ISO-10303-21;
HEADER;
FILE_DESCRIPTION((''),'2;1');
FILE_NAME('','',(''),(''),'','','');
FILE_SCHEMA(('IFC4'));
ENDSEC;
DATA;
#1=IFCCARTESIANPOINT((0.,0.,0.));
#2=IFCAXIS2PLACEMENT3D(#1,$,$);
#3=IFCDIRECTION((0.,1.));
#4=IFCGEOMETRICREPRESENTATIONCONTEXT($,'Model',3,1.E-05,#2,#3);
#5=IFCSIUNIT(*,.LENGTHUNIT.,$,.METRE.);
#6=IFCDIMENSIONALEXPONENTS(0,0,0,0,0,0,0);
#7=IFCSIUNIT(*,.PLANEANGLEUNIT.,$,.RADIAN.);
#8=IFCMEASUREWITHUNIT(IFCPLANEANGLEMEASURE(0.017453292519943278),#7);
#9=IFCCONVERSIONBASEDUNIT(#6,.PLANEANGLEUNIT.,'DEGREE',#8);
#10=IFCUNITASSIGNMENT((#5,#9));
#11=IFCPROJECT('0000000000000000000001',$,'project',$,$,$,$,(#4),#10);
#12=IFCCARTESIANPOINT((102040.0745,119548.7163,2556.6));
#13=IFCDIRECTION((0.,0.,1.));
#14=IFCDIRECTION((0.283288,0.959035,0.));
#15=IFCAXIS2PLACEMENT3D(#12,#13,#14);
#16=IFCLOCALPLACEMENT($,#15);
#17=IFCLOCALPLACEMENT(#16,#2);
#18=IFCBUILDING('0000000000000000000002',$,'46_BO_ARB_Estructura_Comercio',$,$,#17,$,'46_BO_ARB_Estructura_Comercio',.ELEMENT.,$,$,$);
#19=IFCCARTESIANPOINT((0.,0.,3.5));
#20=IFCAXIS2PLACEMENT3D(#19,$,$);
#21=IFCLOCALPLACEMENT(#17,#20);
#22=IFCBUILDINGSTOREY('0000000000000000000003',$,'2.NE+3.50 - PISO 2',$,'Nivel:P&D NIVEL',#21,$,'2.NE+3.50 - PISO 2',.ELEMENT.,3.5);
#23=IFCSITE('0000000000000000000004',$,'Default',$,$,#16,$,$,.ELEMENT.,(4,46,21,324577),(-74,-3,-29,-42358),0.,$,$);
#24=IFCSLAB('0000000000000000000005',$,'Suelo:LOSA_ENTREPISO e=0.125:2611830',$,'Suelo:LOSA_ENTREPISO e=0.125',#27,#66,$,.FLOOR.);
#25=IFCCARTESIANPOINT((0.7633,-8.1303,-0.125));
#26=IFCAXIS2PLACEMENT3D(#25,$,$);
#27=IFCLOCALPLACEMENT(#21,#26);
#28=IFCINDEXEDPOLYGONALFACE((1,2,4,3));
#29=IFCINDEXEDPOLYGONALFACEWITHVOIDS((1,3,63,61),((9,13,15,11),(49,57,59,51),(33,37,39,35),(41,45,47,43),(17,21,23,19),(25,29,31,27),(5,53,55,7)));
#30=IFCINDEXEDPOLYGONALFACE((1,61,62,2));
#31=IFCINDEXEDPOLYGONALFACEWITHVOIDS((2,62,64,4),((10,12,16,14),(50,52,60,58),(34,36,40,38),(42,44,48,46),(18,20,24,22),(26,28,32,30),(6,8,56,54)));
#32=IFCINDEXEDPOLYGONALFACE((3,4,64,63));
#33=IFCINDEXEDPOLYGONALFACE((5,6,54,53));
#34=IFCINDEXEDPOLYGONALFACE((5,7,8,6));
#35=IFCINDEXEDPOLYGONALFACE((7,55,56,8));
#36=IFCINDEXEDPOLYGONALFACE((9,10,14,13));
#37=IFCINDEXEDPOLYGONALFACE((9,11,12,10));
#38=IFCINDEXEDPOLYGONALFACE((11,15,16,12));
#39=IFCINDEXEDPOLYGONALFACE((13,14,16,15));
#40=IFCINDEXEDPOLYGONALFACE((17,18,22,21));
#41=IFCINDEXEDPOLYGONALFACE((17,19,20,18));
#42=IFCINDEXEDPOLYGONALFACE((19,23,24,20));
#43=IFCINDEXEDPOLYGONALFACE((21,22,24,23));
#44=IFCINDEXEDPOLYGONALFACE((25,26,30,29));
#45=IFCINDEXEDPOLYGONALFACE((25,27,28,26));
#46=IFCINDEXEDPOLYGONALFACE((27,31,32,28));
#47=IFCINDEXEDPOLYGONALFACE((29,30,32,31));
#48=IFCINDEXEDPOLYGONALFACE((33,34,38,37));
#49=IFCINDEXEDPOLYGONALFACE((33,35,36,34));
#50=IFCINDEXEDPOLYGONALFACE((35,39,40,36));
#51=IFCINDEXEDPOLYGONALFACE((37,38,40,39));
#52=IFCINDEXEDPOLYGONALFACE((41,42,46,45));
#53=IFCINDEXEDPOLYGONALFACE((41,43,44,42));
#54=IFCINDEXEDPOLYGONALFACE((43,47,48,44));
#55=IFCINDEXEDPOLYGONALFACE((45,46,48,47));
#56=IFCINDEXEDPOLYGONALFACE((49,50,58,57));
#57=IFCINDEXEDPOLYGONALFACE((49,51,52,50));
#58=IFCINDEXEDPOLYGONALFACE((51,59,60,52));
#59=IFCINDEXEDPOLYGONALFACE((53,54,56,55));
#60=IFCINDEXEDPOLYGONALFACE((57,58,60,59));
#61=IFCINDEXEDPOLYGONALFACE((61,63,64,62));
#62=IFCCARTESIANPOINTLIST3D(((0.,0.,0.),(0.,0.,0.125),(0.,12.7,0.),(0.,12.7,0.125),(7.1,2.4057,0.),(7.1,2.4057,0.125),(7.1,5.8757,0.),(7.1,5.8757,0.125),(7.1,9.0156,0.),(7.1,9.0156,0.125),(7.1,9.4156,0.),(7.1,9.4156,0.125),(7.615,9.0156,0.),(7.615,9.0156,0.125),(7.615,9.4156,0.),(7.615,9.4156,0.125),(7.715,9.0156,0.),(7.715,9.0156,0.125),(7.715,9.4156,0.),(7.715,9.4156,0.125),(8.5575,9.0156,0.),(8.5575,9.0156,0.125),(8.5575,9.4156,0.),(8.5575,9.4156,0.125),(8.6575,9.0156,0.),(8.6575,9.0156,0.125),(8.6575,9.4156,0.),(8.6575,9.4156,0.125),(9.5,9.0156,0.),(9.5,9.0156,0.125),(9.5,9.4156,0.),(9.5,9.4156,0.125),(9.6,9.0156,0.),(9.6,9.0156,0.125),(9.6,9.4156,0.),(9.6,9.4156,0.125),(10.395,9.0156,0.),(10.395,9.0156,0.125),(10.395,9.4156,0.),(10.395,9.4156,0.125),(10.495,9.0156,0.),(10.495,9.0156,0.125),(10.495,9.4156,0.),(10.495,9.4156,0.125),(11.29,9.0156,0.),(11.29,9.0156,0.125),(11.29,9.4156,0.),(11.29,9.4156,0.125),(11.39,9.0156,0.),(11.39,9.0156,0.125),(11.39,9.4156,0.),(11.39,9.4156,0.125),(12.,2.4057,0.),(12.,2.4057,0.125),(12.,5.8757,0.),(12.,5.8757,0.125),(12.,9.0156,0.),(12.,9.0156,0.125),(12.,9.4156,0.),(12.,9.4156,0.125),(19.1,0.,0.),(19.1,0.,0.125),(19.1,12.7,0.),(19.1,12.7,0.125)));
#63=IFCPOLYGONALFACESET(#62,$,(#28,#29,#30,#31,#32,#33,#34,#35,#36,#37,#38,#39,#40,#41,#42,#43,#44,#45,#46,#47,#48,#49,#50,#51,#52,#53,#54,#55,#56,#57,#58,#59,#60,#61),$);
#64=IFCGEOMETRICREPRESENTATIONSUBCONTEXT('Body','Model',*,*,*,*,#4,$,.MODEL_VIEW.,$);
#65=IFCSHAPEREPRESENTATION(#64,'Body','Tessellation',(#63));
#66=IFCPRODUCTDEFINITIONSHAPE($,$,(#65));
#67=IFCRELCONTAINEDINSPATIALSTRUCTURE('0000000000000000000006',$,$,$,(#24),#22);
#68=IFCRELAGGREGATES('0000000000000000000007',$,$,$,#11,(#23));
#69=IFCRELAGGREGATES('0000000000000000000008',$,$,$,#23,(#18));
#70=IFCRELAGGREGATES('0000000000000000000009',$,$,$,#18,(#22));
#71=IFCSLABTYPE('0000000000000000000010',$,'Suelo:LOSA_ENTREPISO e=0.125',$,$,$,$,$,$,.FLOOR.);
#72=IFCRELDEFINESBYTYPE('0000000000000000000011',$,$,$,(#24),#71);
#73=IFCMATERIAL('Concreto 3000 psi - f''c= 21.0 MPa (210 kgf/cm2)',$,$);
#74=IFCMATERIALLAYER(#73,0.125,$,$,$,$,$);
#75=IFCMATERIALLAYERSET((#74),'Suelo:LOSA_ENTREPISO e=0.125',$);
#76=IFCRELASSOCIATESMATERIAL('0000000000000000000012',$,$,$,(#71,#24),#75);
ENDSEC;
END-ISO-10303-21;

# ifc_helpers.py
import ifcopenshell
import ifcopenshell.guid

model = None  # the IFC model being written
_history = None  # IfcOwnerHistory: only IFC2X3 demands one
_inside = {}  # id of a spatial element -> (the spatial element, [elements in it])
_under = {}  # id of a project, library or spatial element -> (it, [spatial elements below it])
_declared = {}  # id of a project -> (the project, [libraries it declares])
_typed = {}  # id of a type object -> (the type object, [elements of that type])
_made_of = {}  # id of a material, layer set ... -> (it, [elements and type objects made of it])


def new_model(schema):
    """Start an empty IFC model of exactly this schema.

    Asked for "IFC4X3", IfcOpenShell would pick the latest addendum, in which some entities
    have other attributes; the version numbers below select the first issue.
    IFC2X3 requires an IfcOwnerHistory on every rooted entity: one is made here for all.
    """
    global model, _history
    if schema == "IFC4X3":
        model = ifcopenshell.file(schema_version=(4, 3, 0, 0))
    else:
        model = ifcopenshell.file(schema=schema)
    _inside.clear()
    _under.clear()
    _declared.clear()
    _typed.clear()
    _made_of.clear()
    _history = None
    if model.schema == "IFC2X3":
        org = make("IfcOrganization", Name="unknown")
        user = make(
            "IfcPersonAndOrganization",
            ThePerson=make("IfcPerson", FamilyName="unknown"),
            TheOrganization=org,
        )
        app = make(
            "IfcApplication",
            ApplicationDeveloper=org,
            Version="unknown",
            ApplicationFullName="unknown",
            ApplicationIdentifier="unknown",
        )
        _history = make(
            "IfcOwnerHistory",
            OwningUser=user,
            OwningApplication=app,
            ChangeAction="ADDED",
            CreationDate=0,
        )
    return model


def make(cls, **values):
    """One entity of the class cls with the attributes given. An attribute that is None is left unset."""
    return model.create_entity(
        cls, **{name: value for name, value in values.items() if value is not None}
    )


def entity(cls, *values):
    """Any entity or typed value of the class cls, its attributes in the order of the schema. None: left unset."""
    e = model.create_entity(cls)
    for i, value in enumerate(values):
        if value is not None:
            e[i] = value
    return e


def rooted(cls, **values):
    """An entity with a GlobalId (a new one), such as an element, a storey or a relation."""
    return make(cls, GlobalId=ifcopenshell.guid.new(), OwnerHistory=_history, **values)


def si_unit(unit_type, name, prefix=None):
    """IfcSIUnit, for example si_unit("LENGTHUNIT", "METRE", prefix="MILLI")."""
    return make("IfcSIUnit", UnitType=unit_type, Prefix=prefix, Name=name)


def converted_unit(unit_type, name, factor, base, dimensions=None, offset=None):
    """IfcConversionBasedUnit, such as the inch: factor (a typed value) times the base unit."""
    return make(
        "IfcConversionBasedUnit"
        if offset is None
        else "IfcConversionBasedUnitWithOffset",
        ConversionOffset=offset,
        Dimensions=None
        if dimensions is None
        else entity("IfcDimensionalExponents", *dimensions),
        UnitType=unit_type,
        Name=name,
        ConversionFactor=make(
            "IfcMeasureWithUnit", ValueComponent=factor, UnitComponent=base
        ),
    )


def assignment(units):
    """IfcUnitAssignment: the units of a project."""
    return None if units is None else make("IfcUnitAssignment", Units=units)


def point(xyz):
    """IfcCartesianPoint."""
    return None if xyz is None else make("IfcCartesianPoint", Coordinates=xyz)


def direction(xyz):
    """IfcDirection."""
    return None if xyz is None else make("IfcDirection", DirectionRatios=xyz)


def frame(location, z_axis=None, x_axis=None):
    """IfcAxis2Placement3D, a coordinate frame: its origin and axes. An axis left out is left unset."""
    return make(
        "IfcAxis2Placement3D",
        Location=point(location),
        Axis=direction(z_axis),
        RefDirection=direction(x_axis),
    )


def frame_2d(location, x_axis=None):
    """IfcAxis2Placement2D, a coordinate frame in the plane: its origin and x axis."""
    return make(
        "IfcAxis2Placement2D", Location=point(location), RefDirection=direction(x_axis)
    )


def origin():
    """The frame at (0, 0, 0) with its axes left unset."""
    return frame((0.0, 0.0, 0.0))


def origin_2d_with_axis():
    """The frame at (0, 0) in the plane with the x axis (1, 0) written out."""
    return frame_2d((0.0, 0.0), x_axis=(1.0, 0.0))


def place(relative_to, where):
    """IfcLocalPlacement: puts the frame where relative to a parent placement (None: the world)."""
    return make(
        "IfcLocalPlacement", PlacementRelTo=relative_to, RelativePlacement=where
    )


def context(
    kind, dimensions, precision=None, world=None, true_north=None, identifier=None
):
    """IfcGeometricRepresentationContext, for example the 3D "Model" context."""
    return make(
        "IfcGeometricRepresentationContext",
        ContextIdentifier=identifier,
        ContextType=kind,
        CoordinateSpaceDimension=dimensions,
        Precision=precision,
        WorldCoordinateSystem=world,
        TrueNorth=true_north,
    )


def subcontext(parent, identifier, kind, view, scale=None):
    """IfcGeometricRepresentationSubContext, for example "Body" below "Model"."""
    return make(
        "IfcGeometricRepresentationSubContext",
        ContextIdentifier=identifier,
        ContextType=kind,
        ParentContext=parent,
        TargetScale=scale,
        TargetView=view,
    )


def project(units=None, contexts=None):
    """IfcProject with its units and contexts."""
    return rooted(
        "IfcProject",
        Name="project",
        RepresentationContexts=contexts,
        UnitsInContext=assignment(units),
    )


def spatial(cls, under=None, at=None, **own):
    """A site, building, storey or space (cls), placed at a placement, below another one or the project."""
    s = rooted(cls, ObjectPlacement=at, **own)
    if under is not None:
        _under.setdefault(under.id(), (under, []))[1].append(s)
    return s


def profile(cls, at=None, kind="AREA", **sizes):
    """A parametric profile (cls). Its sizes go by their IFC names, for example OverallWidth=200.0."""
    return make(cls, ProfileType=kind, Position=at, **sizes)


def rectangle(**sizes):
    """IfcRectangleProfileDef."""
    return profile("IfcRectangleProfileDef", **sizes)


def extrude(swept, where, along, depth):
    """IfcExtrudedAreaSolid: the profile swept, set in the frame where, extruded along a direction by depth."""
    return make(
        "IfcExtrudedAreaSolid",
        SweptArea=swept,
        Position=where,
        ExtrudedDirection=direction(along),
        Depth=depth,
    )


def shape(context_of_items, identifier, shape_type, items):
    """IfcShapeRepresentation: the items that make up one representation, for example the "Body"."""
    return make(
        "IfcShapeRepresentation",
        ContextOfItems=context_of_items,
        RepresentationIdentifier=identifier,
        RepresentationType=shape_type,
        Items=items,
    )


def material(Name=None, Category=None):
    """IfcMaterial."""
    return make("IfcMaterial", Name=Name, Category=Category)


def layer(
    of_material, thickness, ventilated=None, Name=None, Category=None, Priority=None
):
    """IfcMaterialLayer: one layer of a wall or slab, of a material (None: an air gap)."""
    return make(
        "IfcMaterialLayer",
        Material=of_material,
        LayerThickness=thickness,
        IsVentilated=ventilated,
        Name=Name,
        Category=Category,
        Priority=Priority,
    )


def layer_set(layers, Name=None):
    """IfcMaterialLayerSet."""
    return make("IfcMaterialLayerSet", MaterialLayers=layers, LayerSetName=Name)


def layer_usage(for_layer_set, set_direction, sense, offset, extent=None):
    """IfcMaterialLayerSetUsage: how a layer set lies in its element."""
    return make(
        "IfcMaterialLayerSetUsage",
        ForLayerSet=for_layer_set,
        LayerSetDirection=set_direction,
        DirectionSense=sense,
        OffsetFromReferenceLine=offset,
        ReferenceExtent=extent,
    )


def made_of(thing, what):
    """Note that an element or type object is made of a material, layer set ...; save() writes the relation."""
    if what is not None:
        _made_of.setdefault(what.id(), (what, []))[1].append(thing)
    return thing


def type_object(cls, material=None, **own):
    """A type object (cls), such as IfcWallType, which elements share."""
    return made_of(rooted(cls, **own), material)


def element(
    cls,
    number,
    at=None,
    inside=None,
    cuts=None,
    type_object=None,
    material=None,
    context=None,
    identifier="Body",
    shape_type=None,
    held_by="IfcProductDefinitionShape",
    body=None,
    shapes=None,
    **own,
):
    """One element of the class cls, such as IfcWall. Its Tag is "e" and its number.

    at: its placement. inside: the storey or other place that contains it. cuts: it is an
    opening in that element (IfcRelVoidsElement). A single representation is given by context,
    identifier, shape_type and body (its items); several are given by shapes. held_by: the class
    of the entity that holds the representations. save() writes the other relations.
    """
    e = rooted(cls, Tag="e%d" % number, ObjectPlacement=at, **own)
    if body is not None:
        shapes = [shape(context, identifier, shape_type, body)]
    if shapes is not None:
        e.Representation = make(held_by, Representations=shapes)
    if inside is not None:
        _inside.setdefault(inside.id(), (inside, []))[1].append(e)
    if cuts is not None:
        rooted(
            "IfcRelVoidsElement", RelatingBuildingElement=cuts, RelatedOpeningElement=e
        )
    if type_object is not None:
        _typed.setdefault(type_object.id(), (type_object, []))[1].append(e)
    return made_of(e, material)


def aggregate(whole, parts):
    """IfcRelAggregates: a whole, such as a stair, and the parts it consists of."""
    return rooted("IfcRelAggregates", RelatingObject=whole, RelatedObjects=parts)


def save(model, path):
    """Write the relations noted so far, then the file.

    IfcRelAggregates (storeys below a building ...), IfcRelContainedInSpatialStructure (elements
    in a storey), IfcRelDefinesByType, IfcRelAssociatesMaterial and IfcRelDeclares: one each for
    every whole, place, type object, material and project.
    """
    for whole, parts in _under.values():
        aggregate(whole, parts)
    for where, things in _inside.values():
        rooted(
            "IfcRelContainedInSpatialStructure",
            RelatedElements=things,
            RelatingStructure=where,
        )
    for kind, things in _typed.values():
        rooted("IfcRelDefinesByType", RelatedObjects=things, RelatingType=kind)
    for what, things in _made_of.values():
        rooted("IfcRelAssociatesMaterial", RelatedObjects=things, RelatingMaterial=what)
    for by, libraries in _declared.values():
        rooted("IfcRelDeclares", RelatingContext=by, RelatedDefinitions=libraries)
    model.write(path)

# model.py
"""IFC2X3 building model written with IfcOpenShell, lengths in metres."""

from ifc_helpers import new_model, entity, si_unit, converted_unit, direction, frame, frame_2d, origin, origin_2d_with_axis, place, context, subcontext, project, spatial, rectangle, extrude, material, layer, layer_set, layer_usage, type_object, element, save


model = new_model("IFC2X3")

# Units and contexts
model_context = context("Model", 3, precision=1e-05, world=origin(), true_north=direction((0.0, 1.0)))
body_context = subcontext(model_context, "Body", "Model", "MODEL_VIEW")
ifc_project = project(units=[si_unit("LENGTHUNIT", "METRE"), converted_unit("PLANEANGLEUNIT", "DEGREE", entity("IfcPlaneAngleMeasure", 0.017453292519943278), si_unit("PLANEANGLEUNIT", "RADIAN"), dimensions=[0, 0, 0, 0, 0, 0, 0])], contexts=[model_context])

# Site, building, storey
site_placement = place(None, frame((102040.0745, 119548.7163, 2556.6), z_axis=(0.0, 0.0, 1.0), x_axis=(0.283288, 0.959035, 0.0)))
site = spatial("IfcSite", under=ifc_project, at=site_placement, Name="Default", CompositionType="ELEMENT", RefLatitude=(4, 46, 21, 324577), RefLongitude=(-74, -3, -29, -42358), RefElevation=0.0)
building_placement = place(site_placement, origin())
building = spatial("IfcBuilding", under=site, at=building_placement, Name="46_BO_ARB_Estructura_Comercio", LongName="46_BO_ARB_Estructura_Comercio", CompositionType="ELEMENT")
storey_placement = place(building_placement, frame((0.0, 0.0, 3.5)))
storey = spatial("IfcBuildingStorey", under=building, at=storey_placement, Name="2.NE+3.50 - PISO 2", ObjectType="Nivel:P&D NIVEL", LongName="2.NE+3.50 - PISO 2", CompositionType="ELEMENT", Elevation=3.5)

# Shared definitions
ifc_material_1 = material(Name="Concreto 3000 psi - f'c= 21.0 MPa (210 kgf/cm2)")

# Slab, openings
ifc_layer = layer(ifc_material_1, 0.125)
ifc_layer_set = layer_set([ifc_layer], Name="Suelo:LOSA_ENTREPISO e=0.125")
ifc_layer_usage = layer_usage(ifc_layer_set, "AXIS3", "POSITIVE", 0.0)
slab_type = type_object("IfcSlabType", Name="Suelo:LOSA_ENTREPISO e=0.125", PredefinedType="FLOOR", material=ifc_layer_set)
slab_placement = place(storey_placement, frame((0.7633, -8.1303, -0.125)))
slab = element("IfcSlab", 1, at=slab_placement, inside=storey, type_object=slab_type, material=ifc_layer_usage, Name="Suelo:LOSA_ENTREPISO e=0.125:2611830", ObjectType="Suelo:LOSA_ENTREPISO e=0.125", PredefinedType="FLOOR", context=body_context, shape_type="SweptSolid", body=[
    extrude(rectangle(XDim=12.7, YDim=19.1, at=frame_2d((0.0, 0.0), x_axis=(0.0, -1.0))), frame((9.55, 6.35, 0.125), z_axis=(0.0, 0.0, -1.0), x_axis=(-1.0, 0.0, 0.0)), (0.0, 0.0, 1.0), 0.125),
])
opening_1_placement = place(slab_placement, origin())
element("IfcOpeningElement", 2, at=opening_1_placement, cuts=slab, ObjectType="Opening", context=body_context, shape_type="SweptSolid", body=[
    extrude(rectangle(XDim=3.47, YDim=4.9, at=frame_2d((0.0, 0.0), x_axis=(1.0, 0.0))), frame((9.55, 4.1407, 0.125), z_axis=(0.0, 0.0, -1.0), x_axis=(0.0, -1.0, 0.0)), (0.0, 0.0, 1.0), 0.125),
])
opening_2_placement = place(slab_placement, origin())
element("IfcOpeningElement", 3, at=opening_2_placement, cuts=slab, ObjectType="Opening", context=body_context, shape_type="SweptSolid", body=[
    extrude(rectangle(XDim=0.515, YDim=0.4, at=origin_2d_with_axis()), frame((7.3575, 9.2156, 0.125), z_axis=(0.0, 0.0, -1.0), x_axis=(-1.0, 0.0, 0.0)), (0.0, 0.0, 1.0), 0.125),
])
opening_3_placement = place(slab_placement, origin())
element("IfcOpeningElement", 4, at=opening_3_placement, cuts=slab, ObjectType="Opening", context=body_context, shape_type="SweptSolid", body=[
    extrude(rectangle(XDim=0.4, YDim=0.8425, at=origin_2d_with_axis()), frame((8.1362, 9.2156, 0.125), z_axis=(0.0, 0.0, -1.0), x_axis=(0.0, -1.0, 0.0)), (0.0, 0.0, 1.0), 0.125),
])
opening_4_placement = place(slab_placement, origin())
element("IfcOpeningElement", 5, at=opening_4_placement, cuts=slab, ObjectType="Opening", context=body_context, shape_type="SweptSolid", body=[
    extrude(rectangle(XDim=0.4, YDim=0.8425, at=frame_2d((0.0, 0.0), x_axis=(1.0, 0.0))), frame((9.0787, 9.2156, 0.125), z_axis=(0.0, 0.0, -1.0), x_axis=(0.0, -1.0, 0.0)), (0.0, 0.0, 1.0), 0.125),
])
opening_5_placement = place(slab_placement, origin())
element("IfcOpeningElement", 6, at=opening_5_placement, cuts=slab, ObjectType="Opening", context=body_context, shape_type="SweptSolid", body=[
    extrude(rectangle(XDim=0.4, YDim=0.795, at=frame_2d((0.0, 0.0), x_axis=(1.0, 0.0))), frame((9.9975, 9.2156, 0.125), z_axis=(0.0, 0.0, -1.0), x_axis=(0.0, -1.0, 0.0)), (0.0, 0.0, 1.0), 0.125),
])
opening_6_placement = place(slab_placement, origin())
element("IfcOpeningElement", 7, at=opening_6_placement, cuts=slab, ObjectType="Opening", context=body_context, shape_type="SweptSolid", body=[
    extrude(rectangle(XDim=0.4, YDim=0.795, at=origin_2d_with_axis()), frame((10.8925, 9.2156, 0.125), z_axis=(0.0, 0.0, -1.0), x_axis=(0.0, -1.0, 0.0)), (0.0, 0.0, 1.0), 0.125),
])
opening_7_placement = place(slab_placement, origin())
element("IfcOpeningElement", 8, at=opening_7_placement, cuts=slab, ObjectType="Opening", context=body_context, shape_type="SweptSolid", body=[
    extrude(rectangle(XDim=0.4, YDim=0.61, at=frame_2d((0.0, 0.0), x_axis=(1.0, 0.0))), frame((11.695, 9.2156, 0.125), z_axis=(0.0, 0.0, -1.0), x_axis=(0.0, -1.0, 0.0)), (0.0, 0.0, 1.0), 0.125),
])

save(model, "model.ifc")
